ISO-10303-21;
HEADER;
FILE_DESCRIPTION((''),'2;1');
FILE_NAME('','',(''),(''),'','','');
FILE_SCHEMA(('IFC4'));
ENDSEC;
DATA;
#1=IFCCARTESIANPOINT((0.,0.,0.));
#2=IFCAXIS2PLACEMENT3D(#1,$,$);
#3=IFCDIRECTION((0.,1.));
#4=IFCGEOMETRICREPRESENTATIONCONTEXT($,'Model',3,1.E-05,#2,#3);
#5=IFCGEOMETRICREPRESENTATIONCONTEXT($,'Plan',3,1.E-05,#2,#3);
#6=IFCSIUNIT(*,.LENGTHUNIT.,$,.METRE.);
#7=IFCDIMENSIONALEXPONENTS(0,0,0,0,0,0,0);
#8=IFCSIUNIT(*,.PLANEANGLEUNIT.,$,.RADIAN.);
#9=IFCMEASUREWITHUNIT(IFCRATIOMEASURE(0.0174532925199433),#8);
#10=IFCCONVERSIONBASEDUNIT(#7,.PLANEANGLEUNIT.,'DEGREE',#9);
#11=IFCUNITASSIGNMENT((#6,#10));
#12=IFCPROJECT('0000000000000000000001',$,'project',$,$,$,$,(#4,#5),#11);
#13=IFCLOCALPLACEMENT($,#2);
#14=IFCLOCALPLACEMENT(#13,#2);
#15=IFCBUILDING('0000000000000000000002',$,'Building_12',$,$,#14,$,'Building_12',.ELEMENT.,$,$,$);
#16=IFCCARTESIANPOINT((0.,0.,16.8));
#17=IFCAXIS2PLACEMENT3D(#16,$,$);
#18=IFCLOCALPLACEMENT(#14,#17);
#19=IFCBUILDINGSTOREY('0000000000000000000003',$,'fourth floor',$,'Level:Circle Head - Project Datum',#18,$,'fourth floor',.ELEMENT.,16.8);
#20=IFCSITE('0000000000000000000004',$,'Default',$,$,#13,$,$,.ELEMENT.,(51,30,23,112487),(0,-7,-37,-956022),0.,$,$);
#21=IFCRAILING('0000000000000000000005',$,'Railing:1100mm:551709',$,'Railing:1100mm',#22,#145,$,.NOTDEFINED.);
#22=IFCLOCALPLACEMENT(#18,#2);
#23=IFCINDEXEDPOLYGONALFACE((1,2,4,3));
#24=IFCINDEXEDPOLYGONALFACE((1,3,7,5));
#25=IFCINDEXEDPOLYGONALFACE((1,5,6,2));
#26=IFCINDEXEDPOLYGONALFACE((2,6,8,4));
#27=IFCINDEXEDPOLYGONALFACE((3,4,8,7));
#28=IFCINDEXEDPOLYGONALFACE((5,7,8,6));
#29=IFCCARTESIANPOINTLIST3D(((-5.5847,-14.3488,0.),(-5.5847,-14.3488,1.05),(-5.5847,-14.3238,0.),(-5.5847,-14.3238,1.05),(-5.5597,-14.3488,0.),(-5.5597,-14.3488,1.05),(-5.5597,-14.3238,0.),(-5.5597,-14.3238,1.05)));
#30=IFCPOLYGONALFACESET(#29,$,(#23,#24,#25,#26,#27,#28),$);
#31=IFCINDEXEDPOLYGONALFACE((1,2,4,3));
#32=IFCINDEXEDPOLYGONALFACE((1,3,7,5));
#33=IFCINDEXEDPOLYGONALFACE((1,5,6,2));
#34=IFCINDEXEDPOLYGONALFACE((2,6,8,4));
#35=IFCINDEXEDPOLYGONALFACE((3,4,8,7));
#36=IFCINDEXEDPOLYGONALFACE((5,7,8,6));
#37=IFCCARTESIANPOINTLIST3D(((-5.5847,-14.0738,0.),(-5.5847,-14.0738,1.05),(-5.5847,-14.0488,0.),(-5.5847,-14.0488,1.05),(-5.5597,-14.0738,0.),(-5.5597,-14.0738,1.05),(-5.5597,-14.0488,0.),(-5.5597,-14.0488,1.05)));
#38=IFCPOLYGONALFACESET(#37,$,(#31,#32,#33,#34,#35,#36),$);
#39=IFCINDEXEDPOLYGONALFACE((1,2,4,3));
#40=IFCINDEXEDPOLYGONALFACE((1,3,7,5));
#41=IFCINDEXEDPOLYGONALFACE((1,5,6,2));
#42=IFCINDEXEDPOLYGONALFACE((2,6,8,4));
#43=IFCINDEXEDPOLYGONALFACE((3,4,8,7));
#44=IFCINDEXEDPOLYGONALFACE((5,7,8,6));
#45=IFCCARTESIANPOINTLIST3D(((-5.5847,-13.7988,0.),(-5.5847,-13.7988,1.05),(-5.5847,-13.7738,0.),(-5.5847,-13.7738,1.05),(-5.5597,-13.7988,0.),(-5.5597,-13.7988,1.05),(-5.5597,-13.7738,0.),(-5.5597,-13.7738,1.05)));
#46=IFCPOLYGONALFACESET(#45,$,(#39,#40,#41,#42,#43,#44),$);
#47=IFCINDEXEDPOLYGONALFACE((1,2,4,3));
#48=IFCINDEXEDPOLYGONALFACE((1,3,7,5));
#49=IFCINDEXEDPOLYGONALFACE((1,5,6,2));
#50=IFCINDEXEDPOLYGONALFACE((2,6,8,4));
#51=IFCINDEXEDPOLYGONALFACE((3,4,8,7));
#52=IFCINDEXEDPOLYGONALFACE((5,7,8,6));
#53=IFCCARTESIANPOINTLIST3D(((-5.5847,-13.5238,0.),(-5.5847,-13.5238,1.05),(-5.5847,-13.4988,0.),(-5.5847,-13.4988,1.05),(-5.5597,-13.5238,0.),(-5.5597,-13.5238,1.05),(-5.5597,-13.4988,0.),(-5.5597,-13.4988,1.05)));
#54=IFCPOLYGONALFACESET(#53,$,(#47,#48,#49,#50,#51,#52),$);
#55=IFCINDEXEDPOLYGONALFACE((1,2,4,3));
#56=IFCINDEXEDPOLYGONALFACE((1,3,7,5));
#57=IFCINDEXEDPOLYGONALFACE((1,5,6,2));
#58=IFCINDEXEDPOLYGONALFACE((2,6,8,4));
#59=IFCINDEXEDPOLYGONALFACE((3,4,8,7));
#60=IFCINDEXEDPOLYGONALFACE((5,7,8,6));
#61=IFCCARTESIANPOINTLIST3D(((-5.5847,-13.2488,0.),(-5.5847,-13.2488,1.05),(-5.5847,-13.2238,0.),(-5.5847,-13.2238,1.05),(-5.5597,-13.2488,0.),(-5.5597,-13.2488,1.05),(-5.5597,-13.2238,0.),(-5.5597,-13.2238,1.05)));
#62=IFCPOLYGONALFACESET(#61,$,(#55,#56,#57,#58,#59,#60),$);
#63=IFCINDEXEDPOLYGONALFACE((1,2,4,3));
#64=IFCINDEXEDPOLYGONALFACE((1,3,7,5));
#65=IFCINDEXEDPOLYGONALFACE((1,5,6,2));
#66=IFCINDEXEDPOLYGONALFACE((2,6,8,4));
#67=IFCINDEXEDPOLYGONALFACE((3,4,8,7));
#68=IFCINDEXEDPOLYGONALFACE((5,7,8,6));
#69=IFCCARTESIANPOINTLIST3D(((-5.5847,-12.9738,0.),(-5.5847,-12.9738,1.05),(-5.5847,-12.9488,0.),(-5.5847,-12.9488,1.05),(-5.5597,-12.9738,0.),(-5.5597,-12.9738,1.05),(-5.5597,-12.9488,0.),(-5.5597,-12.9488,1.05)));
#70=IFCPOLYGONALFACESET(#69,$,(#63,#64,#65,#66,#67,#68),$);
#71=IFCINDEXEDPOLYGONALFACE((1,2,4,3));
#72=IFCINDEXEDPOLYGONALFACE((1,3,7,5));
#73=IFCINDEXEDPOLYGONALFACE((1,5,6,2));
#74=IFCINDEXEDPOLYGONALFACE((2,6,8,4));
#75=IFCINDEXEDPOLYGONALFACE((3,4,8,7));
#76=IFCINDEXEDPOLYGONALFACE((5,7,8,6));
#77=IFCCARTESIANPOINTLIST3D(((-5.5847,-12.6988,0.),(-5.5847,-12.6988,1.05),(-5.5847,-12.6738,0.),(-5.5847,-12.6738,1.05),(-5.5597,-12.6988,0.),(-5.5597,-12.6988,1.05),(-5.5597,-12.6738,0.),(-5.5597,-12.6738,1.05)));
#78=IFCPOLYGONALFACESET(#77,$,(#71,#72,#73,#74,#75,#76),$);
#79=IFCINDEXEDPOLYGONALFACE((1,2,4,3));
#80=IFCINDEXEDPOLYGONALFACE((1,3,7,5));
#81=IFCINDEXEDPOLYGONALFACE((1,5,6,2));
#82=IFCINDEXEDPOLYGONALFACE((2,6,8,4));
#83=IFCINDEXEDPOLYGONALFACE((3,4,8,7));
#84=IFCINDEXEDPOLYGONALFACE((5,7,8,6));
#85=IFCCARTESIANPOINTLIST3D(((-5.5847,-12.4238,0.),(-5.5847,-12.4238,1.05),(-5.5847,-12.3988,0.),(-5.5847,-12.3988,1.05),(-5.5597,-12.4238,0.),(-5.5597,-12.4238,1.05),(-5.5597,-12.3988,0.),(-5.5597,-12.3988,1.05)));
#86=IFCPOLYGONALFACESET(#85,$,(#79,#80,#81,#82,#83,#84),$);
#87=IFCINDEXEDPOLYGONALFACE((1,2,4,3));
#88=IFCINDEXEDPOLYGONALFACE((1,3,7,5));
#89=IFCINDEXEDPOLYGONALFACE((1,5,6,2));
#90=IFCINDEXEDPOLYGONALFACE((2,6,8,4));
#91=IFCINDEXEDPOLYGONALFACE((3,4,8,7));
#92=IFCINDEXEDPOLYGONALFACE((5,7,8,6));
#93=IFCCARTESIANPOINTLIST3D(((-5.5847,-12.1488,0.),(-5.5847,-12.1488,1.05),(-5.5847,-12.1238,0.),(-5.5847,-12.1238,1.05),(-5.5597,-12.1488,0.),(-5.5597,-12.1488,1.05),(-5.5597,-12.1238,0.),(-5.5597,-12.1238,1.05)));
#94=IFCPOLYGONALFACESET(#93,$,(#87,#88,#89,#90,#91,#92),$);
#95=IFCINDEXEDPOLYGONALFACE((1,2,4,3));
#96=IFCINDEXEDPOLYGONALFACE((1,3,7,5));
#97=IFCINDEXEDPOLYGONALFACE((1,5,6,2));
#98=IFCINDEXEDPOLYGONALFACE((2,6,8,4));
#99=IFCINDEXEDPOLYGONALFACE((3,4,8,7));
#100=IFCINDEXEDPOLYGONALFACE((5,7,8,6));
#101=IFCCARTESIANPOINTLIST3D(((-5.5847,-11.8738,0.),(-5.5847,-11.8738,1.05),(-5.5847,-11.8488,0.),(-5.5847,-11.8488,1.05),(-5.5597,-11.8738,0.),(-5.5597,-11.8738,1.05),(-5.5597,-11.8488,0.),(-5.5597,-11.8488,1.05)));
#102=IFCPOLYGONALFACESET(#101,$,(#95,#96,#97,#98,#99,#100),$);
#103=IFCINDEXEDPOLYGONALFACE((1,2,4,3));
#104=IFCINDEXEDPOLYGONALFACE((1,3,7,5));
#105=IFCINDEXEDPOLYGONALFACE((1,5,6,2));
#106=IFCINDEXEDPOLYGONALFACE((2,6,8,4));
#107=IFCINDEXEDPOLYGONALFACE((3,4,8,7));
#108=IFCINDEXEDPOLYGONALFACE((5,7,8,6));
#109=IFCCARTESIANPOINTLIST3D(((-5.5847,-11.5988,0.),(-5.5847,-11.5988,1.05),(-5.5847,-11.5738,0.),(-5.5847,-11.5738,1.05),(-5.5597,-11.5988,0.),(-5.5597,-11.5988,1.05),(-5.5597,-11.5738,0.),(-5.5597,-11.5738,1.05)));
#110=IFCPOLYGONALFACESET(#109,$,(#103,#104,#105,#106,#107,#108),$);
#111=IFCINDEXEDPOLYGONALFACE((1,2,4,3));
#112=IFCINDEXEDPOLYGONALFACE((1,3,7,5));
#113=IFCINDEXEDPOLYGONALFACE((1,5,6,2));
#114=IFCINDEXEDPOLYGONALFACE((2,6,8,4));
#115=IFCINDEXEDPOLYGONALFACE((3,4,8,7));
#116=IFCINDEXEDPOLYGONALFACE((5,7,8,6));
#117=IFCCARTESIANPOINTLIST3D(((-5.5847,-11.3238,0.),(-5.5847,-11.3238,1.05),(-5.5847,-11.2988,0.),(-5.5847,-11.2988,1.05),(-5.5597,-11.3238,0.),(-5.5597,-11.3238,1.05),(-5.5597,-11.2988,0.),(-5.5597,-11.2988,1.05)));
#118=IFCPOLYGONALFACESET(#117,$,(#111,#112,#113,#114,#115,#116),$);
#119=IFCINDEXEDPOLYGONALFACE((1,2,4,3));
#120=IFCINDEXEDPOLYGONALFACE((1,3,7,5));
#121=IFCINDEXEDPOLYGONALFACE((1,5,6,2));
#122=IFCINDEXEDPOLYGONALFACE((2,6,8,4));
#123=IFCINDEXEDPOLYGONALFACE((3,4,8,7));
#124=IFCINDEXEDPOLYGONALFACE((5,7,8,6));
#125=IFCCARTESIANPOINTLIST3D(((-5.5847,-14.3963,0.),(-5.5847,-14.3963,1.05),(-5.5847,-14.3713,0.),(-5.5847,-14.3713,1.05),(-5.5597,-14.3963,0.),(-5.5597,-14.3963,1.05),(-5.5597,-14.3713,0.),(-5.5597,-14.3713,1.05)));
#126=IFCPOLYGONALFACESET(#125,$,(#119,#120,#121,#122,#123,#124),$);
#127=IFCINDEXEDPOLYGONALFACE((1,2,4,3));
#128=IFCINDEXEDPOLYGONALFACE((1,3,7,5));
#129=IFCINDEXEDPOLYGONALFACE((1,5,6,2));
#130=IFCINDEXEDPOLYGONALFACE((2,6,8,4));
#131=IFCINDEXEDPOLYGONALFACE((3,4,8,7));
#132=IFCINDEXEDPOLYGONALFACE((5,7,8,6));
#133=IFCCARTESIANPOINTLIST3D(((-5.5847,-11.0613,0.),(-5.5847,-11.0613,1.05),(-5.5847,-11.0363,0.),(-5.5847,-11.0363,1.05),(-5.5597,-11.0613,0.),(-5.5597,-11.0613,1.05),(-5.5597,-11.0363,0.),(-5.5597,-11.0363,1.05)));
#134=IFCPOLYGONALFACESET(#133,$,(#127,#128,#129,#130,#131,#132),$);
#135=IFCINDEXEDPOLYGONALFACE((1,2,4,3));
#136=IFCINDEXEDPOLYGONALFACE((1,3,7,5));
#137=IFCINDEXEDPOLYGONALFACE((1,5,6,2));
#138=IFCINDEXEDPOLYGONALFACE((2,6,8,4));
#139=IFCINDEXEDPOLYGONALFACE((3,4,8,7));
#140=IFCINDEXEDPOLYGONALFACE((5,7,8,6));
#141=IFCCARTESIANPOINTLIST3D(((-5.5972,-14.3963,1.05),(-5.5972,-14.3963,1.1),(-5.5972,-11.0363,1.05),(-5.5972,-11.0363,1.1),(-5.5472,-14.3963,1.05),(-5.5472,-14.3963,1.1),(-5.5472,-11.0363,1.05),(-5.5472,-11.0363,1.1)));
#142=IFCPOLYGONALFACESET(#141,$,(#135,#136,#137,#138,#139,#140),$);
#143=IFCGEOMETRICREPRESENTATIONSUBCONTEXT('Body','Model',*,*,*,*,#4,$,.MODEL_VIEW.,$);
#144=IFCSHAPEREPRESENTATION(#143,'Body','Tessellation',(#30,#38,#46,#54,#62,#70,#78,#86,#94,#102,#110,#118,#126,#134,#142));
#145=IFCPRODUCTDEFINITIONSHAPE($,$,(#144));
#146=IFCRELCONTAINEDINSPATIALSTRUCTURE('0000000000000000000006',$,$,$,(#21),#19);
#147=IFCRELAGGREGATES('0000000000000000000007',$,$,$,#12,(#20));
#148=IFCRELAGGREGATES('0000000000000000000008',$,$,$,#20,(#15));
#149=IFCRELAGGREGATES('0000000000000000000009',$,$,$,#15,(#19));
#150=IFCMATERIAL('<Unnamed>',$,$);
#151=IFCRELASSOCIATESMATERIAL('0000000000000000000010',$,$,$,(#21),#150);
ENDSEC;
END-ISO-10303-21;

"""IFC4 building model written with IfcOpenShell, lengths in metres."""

from ifc_helpers import new_model, entity, si_unit, converted_unit, direction, frame, origin, place, context, subcontext, project, spatial, indexed_curve, outline, extrude, material, element, save


model = new_model("IFC4")

# Units and contexts
model_context = context("Model", 3, precision=1e-05, world=origin(), true_north=direction((0.0, 1.0)))
plan_context = context("Plan", 3, precision=1e-05, world=origin(), true_north=direction((0.0, 1.0)))
body_context = subcontext(model_context, "Body", "Model", "MODEL_VIEW")
ifc_project = project(units=[si_unit("LENGTHUNIT", "METRE"), converted_unit("PLANEANGLEUNIT", "DEGREE", entity("IfcRatioMeasure", 0.0174532925199433), si_unit("PLANEANGLEUNIT", "RADIAN"), dimensions=[0, 0, 0, 0, 0, 0, 0])], contexts=[model_context, plan_context])

# Site, building, storey
site_placement = place(None, origin())
site = spatial("IfcSite", under=ifc_project, at=site_placement, Name="Default", CompositionType="ELEMENT", RefLatitude=(51, 30, 23, 112487), RefLongitude=(0, -7, -37, -956022), RefElevation=0.0)
building_placement = place(site_placement, origin())
building = spatial("IfcBuilding", under=site, at=building_placement, Name="Building_12", LongName="Building_12", CompositionType="ELEMENT")
storey_placement = place(building_placement, frame((0.0, 0.0, 16.8)))
storey = spatial("IfcBuildingStorey", under=building, at=storey_placement, Name="fourth floor", ObjectType="Level:Circle Head - Project Datum", LongName="fourth floor", CompositionType="ELEMENT", Elevation=16.8)

# Shared definitions
ifc_material_1 = material(Name="<Unnamed>")

# Railing
railing_placement = place(storey_placement, origin())
element("IfcRailing", 1, at=railing_placement, inside=storey, material=ifc_material_1, Name="Railing:1100mm:551709", ObjectType="Railing:1100mm", PredefinedType="NOTDEFINED", context=body_context, shape_type="SweptSolid", body=[
    extrude(outline(indexed_curve([(-0.0125, -0.0125), (0.0125, -0.0125), (0.0125, 0.0125), (-0.0125, 0.0125), (-0.0125, -0.0125)], self_intersect=False)), frame((-5.5722, -14.3363, 0.0), z_axis=(0.0, 0.0, 1.0), x_axis=(0.0, -1.0, 0.0)), (0.0, 0.0, 1.0), 1.05),
    extrude(outline(indexed_curve([(-0.0125, -0.0125), (0.0125, -0.0125), (0.0125, 0.0125), (-0.0125, 0.0125), (-0.0125, -0.0125)], self_intersect=False)), frame((-5.5722, -14.0613, 0.0), z_axis=(0.0, 0.0, 1.0), x_axis=(0.0, -1.0, 0.0)), (0.0, 0.0, 1.0), 1.05),
    extrude(outline(indexed_curve([(-0.0125, -0.0125), (0.0125, -0.0125), (0.0125, 0.0125), (-0.0125, 0.0125), (-0.0125, -0.0125)], self_intersect=False)), frame((-5.5722, -13.7863, 0.0), z_axis=(0.0, 0.0, 1.0), x_axis=(0.0, -1.0, 0.0)), (0.0, 0.0, 1.0), 1.05),
    extrude(outline(indexed_curve([(-0.0125, -0.0125), (0.0125, -0.0125), (0.0125, 0.0125), (-0.0125, 0.0125), (-0.0125, -0.0125)], self_intersect=False)), frame((-5.5722, -13.5113, 0.0), z_axis=(0.0, 0.0, 1.0), x_axis=(0.0, -1.0, 0.0)), (0.0, 0.0, 1.0), 1.05),
    extrude(outline(indexed_curve([(-0.0125, -0.0125), (0.0125, -0.0125), (0.0125, 0.0125), (-0.0125, 0.0125), (-0.0125, -0.0125)], self_intersect=False)), frame((-5.5722, -13.2363, 0.0), z_axis=(0.0, 0.0, 1.0), x_axis=(0.0, -1.0, 0.0)), (0.0, 0.0, 1.0), 1.05),
    extrude(outline(indexed_curve([(-0.0125, -0.0125), (0.0125, -0.0125), (0.0125, 0.0125), (-0.0125, 0.0125), (-0.0125, -0.0125)], self_intersect=False)), frame((-5.5722, -12.9613, 0.0), z_axis=(0.0, 0.0, 1.0), x_axis=(0.0, -1.0, 0.0)), (0.0, 0.0, 1.0), 1.05),
    extrude(outline(indexed_curve([(-0.0125, -0.0125), (0.0125, -0.0125), (0.0125, 0.0125), (-0.0125, 0.0125), (-0.0125, -0.0125)], self_intersect=False)), frame((-5.5722, -12.6863, 0.0), z_axis=(0.0, 0.0, 1.0), x_axis=(0.0, -1.0, 0.0)), (0.0, 0.0, 1.0), 1.05),
    extrude(outline(indexed_curve([(-0.0125, -0.0125), (0.0125, -0.0125), (0.0125, 0.0125), (-0.0125, 0.0125), (-0.0125, -0.0125)], self_intersect=False)), frame((-5.5722, -12.4113, 0.0), z_axis=(0.0, 0.0, 1.0), x_axis=(0.0, -1.0, 0.0)), (0.0, 0.0, 1.0), 1.05),
    extrude(outline(indexed_curve([(-0.0125, -0.0125), (0.0125, -0.0125), (0.0125, 0.0125), (-0.0125, 0.0125), (-0.0125, -0.0125)], self_intersect=False)), frame((-5.5722, -12.1363, 0.0), z_axis=(0.0, 0.0, 1.0), x_axis=(0.0, -1.0, 0.0)), (0.0, 0.0, 1.0), 1.05),
    extrude(outline(indexed_curve([(-0.0125, -0.0125), (0.0125, -0.0125), (0.0125, 0.0125), (-0.0125, 0.0125), (-0.0125, -0.0125)], self_intersect=False)), frame((-5.5722, -11.8613, 0.0), z_axis=(0.0, 0.0, 1.0), x_axis=(0.0, -1.0, 0.0)), (0.0, 0.0, 1.0), 1.05),
    extrude(outline(indexed_curve([(-0.0125, -0.0125), (0.0125, -0.0125), (0.0125, 0.0125), (-0.0125, 0.0125), (-0.0125, -0.0125)], self_intersect=False)), frame((-5.5722, -11.5863, 0.0), z_axis=(0.0, 0.0, 1.0), x_axis=(0.0, -1.0, 0.0)), (0.0, 0.0, 1.0), 1.05),
    extrude(outline(indexed_curve([(-0.0125, -0.0125), (0.0125, -0.0125), (0.0125, 0.0125), (-0.0125, 0.0125), (-0.0125, -0.0125)], self_intersect=False)), frame((-5.5722, -11.3113, 0.0), z_axis=(0.0, 0.0, 1.0), x_axis=(0.0, -1.0, 0.0)), (0.0, 0.0, 1.0), 1.05),
    extrude(outline(indexed_curve([(-0.0125, -0.0125), (0.0125, -0.0125), (0.0125, 0.0125), (-0.0125, 0.0125), (-0.0125, -0.0125)], self_intersect=False)), frame((-5.5722, -14.3838, 0.0), z_axis=(0.0, 0.0, 1.0), x_axis=(0.0, -1.0, 0.0)), (0.0, 0.0, 1.0), 1.05),
    extrude(outline(indexed_curve([(-0.0125, -0.0125), (0.0125, -0.0125), (0.0125, 0.0125), (-0.0125, 0.0125), (-0.0125, -0.0125)], self_intersect=False)), frame((-5.5722, -11.0488, 0.0), z_axis=(0.0, 0.0, 1.0), x_axis=(0.0, -1.0, 0.0)), (0.0, 0.0, 1.0), 1.05),
    extrude(outline(indexed_curve([(-1.68, -0.025), (1.68, -0.025), (1.68, 0.025), (-1.68, 0.025), (-1.68, -0.025)], self_intersect=False)), frame((-5.5722, -12.7163, 1.05), z_axis=(0.0, 0.0, 1.0), x_axis=(0.0, -1.0, 0.0)), (0.0, 0.0, 1.0), 0.05),
])

save(model, "model.ifc")
